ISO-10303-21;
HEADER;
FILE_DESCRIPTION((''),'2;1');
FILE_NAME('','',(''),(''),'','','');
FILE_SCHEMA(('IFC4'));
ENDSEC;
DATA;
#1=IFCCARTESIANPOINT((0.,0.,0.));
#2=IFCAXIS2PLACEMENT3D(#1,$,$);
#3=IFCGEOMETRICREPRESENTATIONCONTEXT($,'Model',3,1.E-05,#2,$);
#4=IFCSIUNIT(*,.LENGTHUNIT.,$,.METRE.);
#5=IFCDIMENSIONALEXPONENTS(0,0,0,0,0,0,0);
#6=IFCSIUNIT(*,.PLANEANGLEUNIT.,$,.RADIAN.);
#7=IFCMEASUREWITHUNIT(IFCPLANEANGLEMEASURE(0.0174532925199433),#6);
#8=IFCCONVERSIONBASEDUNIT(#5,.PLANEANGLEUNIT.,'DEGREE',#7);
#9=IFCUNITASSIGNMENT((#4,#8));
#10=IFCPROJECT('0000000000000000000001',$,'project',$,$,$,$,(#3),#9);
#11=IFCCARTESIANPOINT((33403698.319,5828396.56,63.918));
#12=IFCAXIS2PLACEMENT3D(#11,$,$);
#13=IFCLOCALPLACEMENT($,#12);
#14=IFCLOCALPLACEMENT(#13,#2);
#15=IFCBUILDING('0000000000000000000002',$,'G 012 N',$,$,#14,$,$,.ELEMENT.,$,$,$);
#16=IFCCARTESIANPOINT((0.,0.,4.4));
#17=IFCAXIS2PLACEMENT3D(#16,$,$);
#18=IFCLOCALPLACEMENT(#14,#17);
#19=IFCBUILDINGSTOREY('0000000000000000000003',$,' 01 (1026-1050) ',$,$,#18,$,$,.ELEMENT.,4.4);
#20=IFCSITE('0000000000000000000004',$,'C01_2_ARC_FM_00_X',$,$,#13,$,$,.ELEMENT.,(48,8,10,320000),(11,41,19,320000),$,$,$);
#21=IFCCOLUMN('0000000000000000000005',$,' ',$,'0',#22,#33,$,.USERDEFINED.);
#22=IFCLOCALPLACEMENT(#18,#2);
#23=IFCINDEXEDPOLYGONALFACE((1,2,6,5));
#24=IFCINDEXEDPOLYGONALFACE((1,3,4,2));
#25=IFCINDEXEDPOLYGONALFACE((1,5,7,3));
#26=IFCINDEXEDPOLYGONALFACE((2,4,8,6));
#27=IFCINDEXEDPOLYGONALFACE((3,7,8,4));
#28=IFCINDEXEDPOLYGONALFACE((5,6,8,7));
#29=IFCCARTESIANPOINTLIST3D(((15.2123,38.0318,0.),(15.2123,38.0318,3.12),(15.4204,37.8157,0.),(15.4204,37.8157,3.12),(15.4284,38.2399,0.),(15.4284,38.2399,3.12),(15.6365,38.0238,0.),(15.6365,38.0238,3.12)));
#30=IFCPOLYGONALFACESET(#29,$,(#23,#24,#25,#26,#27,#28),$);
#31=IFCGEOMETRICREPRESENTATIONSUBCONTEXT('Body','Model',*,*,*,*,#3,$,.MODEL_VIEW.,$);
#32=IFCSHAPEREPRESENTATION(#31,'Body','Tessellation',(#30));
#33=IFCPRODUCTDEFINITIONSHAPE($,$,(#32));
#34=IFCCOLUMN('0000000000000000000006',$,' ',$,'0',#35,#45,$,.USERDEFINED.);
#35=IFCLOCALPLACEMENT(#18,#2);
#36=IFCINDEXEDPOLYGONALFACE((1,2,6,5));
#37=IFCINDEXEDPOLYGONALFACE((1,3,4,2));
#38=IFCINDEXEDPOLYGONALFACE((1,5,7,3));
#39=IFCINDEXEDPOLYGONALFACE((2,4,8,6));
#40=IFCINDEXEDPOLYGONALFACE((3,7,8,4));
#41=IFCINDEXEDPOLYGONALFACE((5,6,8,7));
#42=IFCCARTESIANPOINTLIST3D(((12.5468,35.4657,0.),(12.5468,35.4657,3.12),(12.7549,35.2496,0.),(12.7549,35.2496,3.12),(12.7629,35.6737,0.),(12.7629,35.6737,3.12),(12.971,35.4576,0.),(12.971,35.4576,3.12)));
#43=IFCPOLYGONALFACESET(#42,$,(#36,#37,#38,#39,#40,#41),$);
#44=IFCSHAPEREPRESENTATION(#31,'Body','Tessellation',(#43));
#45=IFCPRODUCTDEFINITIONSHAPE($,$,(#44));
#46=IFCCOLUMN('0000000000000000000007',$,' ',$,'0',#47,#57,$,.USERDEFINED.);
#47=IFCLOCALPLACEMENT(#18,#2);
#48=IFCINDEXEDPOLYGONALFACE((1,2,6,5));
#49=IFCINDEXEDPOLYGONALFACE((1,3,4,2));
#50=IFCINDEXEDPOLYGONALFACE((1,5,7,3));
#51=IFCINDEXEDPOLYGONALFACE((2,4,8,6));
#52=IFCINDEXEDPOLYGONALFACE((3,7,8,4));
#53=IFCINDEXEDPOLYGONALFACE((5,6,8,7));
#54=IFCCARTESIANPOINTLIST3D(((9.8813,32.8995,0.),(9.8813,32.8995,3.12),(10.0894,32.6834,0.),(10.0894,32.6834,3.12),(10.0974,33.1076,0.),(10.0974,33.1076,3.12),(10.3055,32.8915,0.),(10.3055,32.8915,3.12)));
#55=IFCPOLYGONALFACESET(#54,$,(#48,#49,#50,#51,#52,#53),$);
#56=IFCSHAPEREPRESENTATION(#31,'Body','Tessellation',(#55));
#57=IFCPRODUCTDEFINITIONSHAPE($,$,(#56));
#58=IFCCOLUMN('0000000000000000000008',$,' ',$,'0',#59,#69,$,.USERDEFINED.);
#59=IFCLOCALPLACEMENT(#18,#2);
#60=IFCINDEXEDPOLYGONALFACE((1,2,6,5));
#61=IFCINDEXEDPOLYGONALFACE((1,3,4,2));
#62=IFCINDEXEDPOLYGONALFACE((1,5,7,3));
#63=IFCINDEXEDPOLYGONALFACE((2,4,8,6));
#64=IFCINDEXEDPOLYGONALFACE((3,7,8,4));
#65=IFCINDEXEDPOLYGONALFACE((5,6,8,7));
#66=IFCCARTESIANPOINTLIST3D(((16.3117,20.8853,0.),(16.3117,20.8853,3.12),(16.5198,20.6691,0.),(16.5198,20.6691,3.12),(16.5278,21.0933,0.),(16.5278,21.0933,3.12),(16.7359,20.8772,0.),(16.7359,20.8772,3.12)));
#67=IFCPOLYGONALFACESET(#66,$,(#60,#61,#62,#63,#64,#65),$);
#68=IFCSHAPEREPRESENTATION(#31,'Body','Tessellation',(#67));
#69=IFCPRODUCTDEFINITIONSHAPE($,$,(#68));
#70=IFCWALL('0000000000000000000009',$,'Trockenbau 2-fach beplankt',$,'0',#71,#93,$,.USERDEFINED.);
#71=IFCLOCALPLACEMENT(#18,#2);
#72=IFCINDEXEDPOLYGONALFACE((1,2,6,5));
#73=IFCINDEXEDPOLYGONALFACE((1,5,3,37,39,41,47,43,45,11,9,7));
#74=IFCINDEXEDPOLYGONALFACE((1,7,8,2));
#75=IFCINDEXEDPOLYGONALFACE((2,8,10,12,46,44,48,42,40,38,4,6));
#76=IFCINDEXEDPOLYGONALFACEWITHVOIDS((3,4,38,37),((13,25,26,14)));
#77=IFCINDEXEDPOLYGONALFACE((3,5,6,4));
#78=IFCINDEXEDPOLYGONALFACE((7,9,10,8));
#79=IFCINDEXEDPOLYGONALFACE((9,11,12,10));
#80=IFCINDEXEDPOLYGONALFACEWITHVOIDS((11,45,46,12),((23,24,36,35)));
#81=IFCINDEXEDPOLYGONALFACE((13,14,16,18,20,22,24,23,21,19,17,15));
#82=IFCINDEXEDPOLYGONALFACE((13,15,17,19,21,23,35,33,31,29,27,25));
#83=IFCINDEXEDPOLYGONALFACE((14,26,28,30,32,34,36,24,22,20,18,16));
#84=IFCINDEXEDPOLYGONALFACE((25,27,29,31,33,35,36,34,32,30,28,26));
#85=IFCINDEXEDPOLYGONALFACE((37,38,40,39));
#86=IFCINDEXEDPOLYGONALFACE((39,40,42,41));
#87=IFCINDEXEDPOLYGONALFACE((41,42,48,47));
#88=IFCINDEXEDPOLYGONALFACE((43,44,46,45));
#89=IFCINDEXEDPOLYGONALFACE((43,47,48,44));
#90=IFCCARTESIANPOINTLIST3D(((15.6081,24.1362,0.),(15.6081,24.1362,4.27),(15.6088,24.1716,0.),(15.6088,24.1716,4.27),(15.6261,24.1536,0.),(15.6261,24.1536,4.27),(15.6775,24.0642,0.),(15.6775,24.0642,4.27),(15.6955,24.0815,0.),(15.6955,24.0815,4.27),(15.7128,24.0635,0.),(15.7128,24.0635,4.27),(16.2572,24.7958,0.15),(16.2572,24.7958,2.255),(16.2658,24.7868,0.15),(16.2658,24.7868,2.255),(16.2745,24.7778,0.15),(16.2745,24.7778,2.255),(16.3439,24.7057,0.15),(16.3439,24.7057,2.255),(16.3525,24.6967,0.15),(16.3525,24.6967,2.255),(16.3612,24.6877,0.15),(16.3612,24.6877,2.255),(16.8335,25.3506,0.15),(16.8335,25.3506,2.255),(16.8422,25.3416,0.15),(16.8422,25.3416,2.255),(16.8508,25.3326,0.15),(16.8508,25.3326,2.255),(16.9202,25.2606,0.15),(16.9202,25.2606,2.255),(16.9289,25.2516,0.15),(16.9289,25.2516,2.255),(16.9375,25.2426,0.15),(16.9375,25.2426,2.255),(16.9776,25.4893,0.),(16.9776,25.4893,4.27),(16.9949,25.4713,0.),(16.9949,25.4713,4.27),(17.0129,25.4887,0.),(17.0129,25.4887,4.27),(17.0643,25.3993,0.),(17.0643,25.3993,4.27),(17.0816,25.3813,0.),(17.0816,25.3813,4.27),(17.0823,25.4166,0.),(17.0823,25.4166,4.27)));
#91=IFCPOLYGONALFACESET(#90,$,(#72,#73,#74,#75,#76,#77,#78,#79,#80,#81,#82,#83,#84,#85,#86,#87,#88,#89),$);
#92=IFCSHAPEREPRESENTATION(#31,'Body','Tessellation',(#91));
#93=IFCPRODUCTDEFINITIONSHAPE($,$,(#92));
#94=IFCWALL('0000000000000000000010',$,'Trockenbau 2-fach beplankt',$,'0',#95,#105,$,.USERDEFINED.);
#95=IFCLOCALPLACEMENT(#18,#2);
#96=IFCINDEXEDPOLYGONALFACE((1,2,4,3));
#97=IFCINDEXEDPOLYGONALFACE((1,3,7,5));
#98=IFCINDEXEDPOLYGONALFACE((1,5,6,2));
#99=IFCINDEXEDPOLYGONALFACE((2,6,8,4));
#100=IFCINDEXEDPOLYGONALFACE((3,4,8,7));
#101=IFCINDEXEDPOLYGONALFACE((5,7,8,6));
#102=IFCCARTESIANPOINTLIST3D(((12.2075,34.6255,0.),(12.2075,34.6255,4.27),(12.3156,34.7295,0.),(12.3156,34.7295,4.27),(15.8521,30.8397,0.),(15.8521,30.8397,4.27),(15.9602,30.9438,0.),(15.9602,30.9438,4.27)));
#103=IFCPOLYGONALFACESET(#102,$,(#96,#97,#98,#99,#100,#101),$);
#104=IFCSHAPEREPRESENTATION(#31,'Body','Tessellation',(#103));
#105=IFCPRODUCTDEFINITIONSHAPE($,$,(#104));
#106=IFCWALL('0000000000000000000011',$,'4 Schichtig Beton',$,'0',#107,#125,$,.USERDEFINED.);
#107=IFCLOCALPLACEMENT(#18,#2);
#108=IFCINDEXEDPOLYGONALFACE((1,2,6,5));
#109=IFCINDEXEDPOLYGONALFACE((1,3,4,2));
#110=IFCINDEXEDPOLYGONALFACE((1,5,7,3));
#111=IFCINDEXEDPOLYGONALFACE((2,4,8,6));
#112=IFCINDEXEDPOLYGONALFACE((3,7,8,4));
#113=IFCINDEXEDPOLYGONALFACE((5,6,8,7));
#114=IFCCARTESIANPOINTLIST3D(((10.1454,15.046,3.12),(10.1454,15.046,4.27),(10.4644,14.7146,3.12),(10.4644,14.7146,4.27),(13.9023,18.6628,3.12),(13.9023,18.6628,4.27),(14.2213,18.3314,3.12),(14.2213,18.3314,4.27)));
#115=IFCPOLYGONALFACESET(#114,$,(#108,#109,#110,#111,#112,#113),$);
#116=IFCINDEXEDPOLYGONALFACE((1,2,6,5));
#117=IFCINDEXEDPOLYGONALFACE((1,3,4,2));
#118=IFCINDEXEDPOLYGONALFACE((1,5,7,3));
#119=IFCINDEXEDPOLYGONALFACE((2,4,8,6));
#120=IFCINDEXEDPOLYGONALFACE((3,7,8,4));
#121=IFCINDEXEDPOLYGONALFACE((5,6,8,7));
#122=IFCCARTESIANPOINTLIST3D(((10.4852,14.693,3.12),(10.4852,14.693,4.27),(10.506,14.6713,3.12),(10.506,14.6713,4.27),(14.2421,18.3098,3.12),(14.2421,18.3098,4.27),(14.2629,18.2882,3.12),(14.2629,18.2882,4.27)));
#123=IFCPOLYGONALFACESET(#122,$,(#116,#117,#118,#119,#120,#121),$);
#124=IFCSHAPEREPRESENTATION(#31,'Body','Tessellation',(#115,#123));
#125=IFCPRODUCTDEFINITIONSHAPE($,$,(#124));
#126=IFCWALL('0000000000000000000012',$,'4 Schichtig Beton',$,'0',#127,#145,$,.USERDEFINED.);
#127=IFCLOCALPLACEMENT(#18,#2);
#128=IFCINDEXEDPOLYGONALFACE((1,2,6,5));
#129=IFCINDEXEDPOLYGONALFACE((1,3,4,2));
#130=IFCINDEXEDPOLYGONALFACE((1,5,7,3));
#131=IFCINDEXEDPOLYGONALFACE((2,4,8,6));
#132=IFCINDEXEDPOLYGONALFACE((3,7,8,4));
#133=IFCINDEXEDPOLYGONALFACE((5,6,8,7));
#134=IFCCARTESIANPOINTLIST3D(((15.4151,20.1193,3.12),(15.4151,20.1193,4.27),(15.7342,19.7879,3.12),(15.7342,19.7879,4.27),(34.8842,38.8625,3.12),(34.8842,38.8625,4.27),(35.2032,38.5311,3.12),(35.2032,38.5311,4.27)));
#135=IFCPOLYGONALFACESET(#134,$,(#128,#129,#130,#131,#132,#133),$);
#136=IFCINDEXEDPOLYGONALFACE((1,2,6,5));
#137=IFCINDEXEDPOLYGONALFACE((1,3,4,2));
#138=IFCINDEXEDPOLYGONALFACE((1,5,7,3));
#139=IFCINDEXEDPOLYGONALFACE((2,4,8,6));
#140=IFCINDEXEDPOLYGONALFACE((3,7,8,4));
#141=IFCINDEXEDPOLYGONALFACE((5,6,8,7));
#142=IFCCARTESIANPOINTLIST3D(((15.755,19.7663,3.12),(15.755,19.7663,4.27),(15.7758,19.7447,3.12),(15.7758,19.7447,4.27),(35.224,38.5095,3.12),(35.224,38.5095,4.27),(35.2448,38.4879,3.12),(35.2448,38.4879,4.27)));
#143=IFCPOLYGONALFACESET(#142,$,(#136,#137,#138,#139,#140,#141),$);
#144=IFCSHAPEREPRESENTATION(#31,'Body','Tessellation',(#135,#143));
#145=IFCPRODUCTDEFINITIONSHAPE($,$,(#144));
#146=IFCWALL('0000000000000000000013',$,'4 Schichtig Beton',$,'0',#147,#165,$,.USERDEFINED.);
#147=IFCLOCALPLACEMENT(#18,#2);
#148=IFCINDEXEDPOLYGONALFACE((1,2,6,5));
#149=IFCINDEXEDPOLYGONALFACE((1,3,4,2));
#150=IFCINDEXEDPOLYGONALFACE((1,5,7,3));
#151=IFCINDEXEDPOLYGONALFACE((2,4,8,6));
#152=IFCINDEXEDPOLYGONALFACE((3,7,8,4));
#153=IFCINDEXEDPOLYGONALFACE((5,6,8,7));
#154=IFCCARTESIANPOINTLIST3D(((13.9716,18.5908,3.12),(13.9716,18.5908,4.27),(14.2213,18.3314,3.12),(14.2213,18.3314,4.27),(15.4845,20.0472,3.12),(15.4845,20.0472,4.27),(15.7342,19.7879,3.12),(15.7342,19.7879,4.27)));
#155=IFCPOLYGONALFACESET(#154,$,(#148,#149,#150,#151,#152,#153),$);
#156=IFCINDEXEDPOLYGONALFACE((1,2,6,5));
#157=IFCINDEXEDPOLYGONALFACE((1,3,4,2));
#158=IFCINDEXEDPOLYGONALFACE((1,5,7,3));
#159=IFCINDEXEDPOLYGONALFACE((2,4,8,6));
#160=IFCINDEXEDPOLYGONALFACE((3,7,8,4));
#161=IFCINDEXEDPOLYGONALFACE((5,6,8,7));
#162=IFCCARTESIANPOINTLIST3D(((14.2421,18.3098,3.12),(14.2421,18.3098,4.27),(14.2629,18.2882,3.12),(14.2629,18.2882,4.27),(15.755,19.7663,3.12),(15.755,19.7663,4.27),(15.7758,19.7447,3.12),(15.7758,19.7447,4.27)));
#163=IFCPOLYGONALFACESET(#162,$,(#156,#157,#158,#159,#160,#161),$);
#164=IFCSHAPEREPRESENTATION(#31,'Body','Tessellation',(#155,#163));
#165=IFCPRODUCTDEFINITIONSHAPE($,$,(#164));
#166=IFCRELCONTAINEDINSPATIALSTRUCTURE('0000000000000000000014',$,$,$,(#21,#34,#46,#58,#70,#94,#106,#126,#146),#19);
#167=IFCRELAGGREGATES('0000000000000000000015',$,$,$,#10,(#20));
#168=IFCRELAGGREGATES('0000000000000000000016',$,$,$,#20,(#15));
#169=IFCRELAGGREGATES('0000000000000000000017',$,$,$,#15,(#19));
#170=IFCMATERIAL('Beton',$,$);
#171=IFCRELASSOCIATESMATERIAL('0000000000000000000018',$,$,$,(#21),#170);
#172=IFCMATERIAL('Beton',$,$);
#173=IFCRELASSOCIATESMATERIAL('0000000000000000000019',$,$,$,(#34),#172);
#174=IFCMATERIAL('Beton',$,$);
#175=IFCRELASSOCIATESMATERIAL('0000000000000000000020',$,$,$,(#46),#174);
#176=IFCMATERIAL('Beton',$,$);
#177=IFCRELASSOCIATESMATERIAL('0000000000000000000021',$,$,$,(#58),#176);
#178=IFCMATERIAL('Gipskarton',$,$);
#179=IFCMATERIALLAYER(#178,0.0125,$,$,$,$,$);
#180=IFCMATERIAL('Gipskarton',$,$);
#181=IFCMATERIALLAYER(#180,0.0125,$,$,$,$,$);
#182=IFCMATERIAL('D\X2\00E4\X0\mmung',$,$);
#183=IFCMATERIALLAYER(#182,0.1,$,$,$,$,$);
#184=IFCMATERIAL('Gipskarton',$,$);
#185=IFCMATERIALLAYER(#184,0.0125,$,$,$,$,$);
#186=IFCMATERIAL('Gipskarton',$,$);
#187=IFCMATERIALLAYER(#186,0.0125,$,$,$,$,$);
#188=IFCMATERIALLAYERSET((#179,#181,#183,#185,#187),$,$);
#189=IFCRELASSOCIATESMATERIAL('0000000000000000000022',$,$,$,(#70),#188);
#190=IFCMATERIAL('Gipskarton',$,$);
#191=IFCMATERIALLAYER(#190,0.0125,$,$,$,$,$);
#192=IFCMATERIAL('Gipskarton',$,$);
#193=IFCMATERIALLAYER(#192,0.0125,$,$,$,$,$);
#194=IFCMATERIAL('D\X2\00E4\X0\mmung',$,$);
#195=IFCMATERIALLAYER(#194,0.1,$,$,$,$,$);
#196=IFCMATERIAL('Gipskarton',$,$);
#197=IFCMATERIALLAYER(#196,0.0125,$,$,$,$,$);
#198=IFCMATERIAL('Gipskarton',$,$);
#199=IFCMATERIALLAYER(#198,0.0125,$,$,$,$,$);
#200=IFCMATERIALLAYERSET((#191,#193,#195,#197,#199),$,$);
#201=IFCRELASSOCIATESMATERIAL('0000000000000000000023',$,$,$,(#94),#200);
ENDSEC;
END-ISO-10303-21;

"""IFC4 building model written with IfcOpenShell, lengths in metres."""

from ifc_helpers import new_model, entity, si_unit, converted_unit, frame, frame_2d, origin, origin_with_axes, place, context, subcontext, project, spatial, polyline, rectangle, outline, extrude, material, layer, layer_set, layer_usage, element, save


model = new_model("IFC4")

# Units and contexts
model_context = context("Model", 3, precision=1e-05, world=origin())
body_context = subcontext(model_context, "Body", "Model", "MODEL_VIEW")
ifc_project = project(units=[si_unit("LENGTHUNIT", "METRE"), converted_unit("PLANEANGLEUNIT", "DEGREE", entity("IfcPlaneAngleMeasure", 0.0174532925199433), si_unit("PLANEANGLEUNIT", "RADIAN"), dimensions=[0, 0, 0, 0, 0, 0, 0])], contexts=[model_context])

# Site, building, storey
site_placement = place(None, frame((33403698.319, 5828396.56, 63.918)))
site = spatial("IfcSite", under=ifc_project, at=site_placement, Name="C01_2_ARC_FM_00_X", CompositionType="ELEMENT", RefLatitude=(48, 8, 10, 320000), RefLongitude=(11, 41, 19, 320000))
building_placement = place(site_placement, origin())
building = spatial("IfcBuilding", under=site, at=building_placement, Name="G 012 N", CompositionType="ELEMENT")
storey_placement = place(building_placement, frame((0.0, 0.0, 4.4)))
storey = spatial("IfcBuildingStorey", under=building, at=storey_placement, Name=" 01 (1026-1050) ", CompositionType="ELEMENT", Elevation=4.4)

# Columns
ifc_material_1 = material(Name="Beton")
column_1_placement = place(storey_placement, frame((15.4204, 37.8157, 0.0)))
element("IfcColumn", 1, at=column_1_placement, inside=storey, material=ifc_material_1, Name=" ", ObjectType="0", PredefinedType="USERDEFINED", context=body_context, shape_type="SweptSolid", body=[
    extrude(rectangle(XDim=0.3, YDim=0.3, at=frame_2d((0.004, 0.2121), x_axis=(0.720408, 0.693551))), origin_with_axes(), (0.0, 0.0, 1.0), 3.12),
])
ifc_material_2 = material(Name="Beton")
column_2_placement = place(storey_placement, frame((12.7549, 35.2496, 0.0)))
element("IfcColumn", 2, at=column_2_placement, inside=storey, material=ifc_material_2, Name=" ", ObjectType="0", PredefinedType="USERDEFINED", context=body_context, shape_type="SweptSolid", body=[
    extrude(rectangle(XDim=0.3, YDim=0.3, at=frame_2d((0.004, 0.2121), x_axis=(0.720408, 0.693551))), origin_with_axes(), (0.0, 0.0, 1.0), 3.12),
])
ifc_material_3 = material(Name="Beton")
column_3_placement = place(storey_placement, frame((10.0894, 32.6834, 0.0)))
element("IfcColumn", 3, at=column_3_placement, inside=storey, material=ifc_material_3, Name=" ", ObjectType="0", PredefinedType="USERDEFINED", context=body_context, shape_type="SweptSolid", body=[
    extrude(rectangle(XDim=0.3, YDim=0.3, at=frame_2d((0.004, 0.2121), x_axis=(0.720408, 0.693551))), origin_with_axes(), (0.0, 0.0, 1.0), 3.12),
])
ifc_material_4 = material(Name="Beton")
column_4_placement = place(storey_placement, frame((16.5198, 20.6691, 0.0)))
element("IfcColumn", 4, at=column_4_placement, inside=storey, material=ifc_material_4, Name=" ", ObjectType="0", PredefinedType="USERDEFINED", context=body_context, shape_type="SweptSolid", body=[
    extrude(rectangle(XDim=0.3, YDim=0.3, at=frame_2d((0.004, 0.2121), x_axis=(0.720408, 0.693551))), origin_with_axes(), (0.0, 0.0, 1.0), 3.12),
])

# Wall, opening
ifc_material_5 = material(Name="Gipskarton")
ifc_layer_1 = layer(ifc_material_5, 0.0125)
ifc_material_6 = material(Name="Gipskarton")
ifc_layer_2 = layer(ifc_material_6, 0.0125)
ifc_material_7 = material(Name="Dämmung")
ifc_layer_3 = layer(ifc_material_7, 0.1)
ifc_material_8 = material(Name="Gipskarton")
ifc_layer_4 = layer(ifc_material_8, 0.0125)
ifc_material_9 = material(Name="Gipskarton")
ifc_layer_5 = layer(ifc_material_9, 0.0125)
ifc_layer_set_1 = layer_set([ifc_layer_1, ifc_layer_2, ifc_layer_3, ifc_layer_4, ifc_layer_5])
ifc_layer_usage_1 = layer_usage(ifc_layer_set_1, "AXIS2", "POSITIVE", 0.0)
wall_1_placement = place(storey_placement, frame((16.9776, 25.4893, 0.0), z_axis=(0.0, 0.0, 1.0), x_axis=(-0.720408, -0.693551, 0.0)))
wall_1 = element("IfcWall", 5, at=wall_1_placement, inside=storey, material=ifc_layer_usage_1, Name="Trockenbau 2-fach beplankt", ObjectType="0", PredefinedType="USERDEFINED", context=body_context, shape_type="SweptSolid", body=[
    extrude(outline(polyline([(-1.9754, -0.0774), (-0.0754, -0.0774), (-0.0754, -0.0524), (-0.0504, -0.0524), (-0.0504, 0.0476), (-0.0754, 0.0476), (-0.0754, 0.0726), (-1.9754, 0.0726), (-1.9754, 0.0476), (-2.0004, 0.0476), (-2.0004, -0.0524), (-1.9754, -0.0524), (-1.9754, -0.0774)])), frame((1.9754, 0.0774, 0.0), z_axis=(0.0, 0.0, 1.0), x_axis=(1.0, 0.0, 0.0)), (0.0, 0.0, 1.0), 4.27),
])
opening_1_placement = place(wall_1_placement, frame((0.2, 0.0, 0.15), z_axis=(0.0, 1.0, 0.0), x_axis=(0.0, 0.0, 1.0)))
element("IfcOpeningElement", 6, at=opening_1_placement, cuts=wall_1, ObjectType="0", PredefinedType="USERDEFINED", context=body_context, shape_type="SweptSolid", body=[
    extrude(outline(polyline([(0.0, 0.8), (2.105, 0.8), (2.105, 0.0), (0.0, 0.0), (0.0, 0.8)])), origin_with_axes(), (0.0, 0.0, 1.0), 0.0125),
    extrude(outline(polyline([(0.0, 0.8), (2.105, 0.8), (2.105, 0.0), (0.0, 0.0), (0.0, 0.8)])), frame((0.0, 0.0, 0.0125), z_axis=(0.0, 0.0, 1.0), x_axis=(1.0, 0.0, 0.0)), (0.0, 0.0, 1.0), 0.0125),
    extrude(outline(polyline([(0.0, 0.8), (2.105, 0.8), (2.105, 0.0), (0.0, 0.0), (0.0, 0.8)])), frame((0.0, 0.0, 0.025), z_axis=(0.0, 0.0, 1.0), x_axis=(1.0, 0.0, 0.0)), (0.0, 0.0, 1.0), 0.1),
    extrude(outline(polyline([(0.0, 0.8), (2.105, 0.8), (2.105, 0.0), (0.0, 0.0), (0.0, 0.8)])), frame((0.0, 0.0, 0.125), z_axis=(0.0, 0.0, 1.0), x_axis=(1.0, 0.0, 0.0)), (0.0, 0.0, 1.0), 0.0125),
    extrude(outline(polyline([(0.0, 0.8), (2.105, 0.8), (2.105, 0.0), (0.0, 0.0), (0.0, 0.8)])), frame((0.0, 0.0, 0.1375), z_axis=(0.0, 0.0, 1.0), x_axis=(1.0, 0.0, 0.0)), (0.0, 0.0, 1.0), 0.0125),
])

# Walls
ifc_material_10 = material(Name="Gipskarton")
ifc_layer_6 = layer(ifc_material_10, 0.0125)
ifc_material_11 = material(Name="Gipskarton")
ifc_layer_7 = layer(ifc_material_11, 0.0125)
ifc_material_12 = material(Name="Dämmung")
ifc_layer_8 = layer(ifc_material_12, 0.1)
ifc_material_13 = material(Name="Gipskarton")
ifc_layer_9 = layer(ifc_material_13, 0.0125)
ifc_material_14 = material(Name="Gipskarton")
ifc_layer_10 = layer(ifc_material_14, 0.0125)
ifc_layer_set_2 = layer_set([ifc_layer_6, ifc_layer_7, ifc_layer_8, ifc_layer_9, ifc_layer_10])
ifc_layer_usage_2 = layer_usage(ifc_layer_set_2, "AXIS2", "POSITIVE", 0.0)
wall_2_placement = place(storey_placement, frame((15.9602, 30.9438, 0.0), z_axis=(0.0, 0.0, 1.0), x_axis=(-0.693551, 0.720408, 0.0)))
element("IfcWall", 7, at=wall_2_placement, inside=storey, material=ifc_layer_usage_2, Name="Trockenbau 2-fach beplankt", ObjectType="0", PredefinedType="USERDEFINED", context=body_context, shape_type="SweptSolid", body=[
    extrude(rectangle(XDim=5.255, YDim=0.15, at=frame_2d((2.6275, 0.075), x_axis=(1.0, 0.0))), origin_with_axes(), (0.0, 0.0, 1.0), 4.27),
])
wall_3_placement = place(storey_placement, frame((10.506, 14.6713, 3.12), z_axis=(0.0, 0.0, 1.0), x_axis=(0.720408, 0.693551, 0.0)))
element("IfcWall", 8, at=wall_3_placement, inside=storey, Name="4 Schichtig Beton", ObjectType="0", PredefinedType="USERDEFINED", context=body_context, shape_type="SweptSolid", body=[
    extrude(rectangle(XDim=0.46, YDim=5.215, at=frame_2d((2.6075, -0.23), x_axis=(0.0, -1.0))), frame((0.0, 0.52, 0.0), z_axis=(0.0, 0.0, 1.0), x_axis=(1.0, 0.0, 0.0)), (0.0, 0.0, 1.0), 1.15),
    extrude(rectangle(XDim=5.215, YDim=0.03, at=frame_2d((-2.6075, -0.015), x_axis=(-1.0, 0.0))), frame((5.215, 0.03, 0.0), z_axis=(0.0, 0.0, 1.0), x_axis=(1.0, 0.0, 0.0)), (0.0, 0.0, 1.0), 1.15),
])
wall_4_placement = place(storey_placement, frame((15.7758, 19.7447, 3.12), z_axis=(0.0, 0.0, 1.0), x_axis=(0.720408, 0.693551, 0.0)))
element("IfcWall", 9, at=wall_4_placement, inside=storey, Name="4 Schichtig Beton", ObjectType="0", PredefinedType="USERDEFINED", context=body_context, shape_type="SweptSolid", body=[
    extrude(rectangle(XDim=0.46, YDim=27.025, at=frame_2d((13.5125, -0.23), x_axis=(0.0, -1.0))), frame((0.0, 0.52, 0.0), z_axis=(0.0, 0.0, 1.0), x_axis=(1.0, 0.0, 0.0)), (0.0, 0.0, 1.0), 1.15),
    extrude(rectangle(XDim=27.025, YDim=0.03, at=frame_2d((-13.5125, -0.015), x_axis=(-1.0, 0.0))), frame((27.025, 0.03, 0.0), z_axis=(0.0, 0.0, 1.0), x_axis=(1.0, 0.0, 0.0)), (0.0, 0.0, 1.0), 1.15),
])
wall_5_placement = place(storey_placement, frame((14.2629, 18.2882, 3.12), z_axis=(0.0, 0.0, 1.0), x_axis=(0.720408, 0.693551, 0.0)))
element("IfcWall", 10, at=wall_5_placement, inside=storey, Name="4 Schichtig Beton", ObjectType="0", PredefinedType="USERDEFINED", context=body_context, shape_type="SweptSolid", body=[
    extrude(rectangle(XDim=0.36, YDim=2.1, at=frame_2d((1.05, -0.18), x_axis=(0.0, -1.0))), frame((0.0, 0.42, 0.0), z_axis=(0.0, 0.0, 1.0), x_axis=(1.0, 0.0, 0.0)), (0.0, 0.0, 1.0), 1.15),
    extrude(rectangle(XDim=2.1, YDim=0.03, at=frame_2d((-1.05, -0.015), x_axis=(-1.0, 0.0))), frame((2.1, 0.03, 0.0), z_axis=(0.0, 0.0, 1.0), x_axis=(1.0, 0.0, 0.0)), (0.0, 0.0, 1.0), 1.15),
])

save(model, "model.ifc")
